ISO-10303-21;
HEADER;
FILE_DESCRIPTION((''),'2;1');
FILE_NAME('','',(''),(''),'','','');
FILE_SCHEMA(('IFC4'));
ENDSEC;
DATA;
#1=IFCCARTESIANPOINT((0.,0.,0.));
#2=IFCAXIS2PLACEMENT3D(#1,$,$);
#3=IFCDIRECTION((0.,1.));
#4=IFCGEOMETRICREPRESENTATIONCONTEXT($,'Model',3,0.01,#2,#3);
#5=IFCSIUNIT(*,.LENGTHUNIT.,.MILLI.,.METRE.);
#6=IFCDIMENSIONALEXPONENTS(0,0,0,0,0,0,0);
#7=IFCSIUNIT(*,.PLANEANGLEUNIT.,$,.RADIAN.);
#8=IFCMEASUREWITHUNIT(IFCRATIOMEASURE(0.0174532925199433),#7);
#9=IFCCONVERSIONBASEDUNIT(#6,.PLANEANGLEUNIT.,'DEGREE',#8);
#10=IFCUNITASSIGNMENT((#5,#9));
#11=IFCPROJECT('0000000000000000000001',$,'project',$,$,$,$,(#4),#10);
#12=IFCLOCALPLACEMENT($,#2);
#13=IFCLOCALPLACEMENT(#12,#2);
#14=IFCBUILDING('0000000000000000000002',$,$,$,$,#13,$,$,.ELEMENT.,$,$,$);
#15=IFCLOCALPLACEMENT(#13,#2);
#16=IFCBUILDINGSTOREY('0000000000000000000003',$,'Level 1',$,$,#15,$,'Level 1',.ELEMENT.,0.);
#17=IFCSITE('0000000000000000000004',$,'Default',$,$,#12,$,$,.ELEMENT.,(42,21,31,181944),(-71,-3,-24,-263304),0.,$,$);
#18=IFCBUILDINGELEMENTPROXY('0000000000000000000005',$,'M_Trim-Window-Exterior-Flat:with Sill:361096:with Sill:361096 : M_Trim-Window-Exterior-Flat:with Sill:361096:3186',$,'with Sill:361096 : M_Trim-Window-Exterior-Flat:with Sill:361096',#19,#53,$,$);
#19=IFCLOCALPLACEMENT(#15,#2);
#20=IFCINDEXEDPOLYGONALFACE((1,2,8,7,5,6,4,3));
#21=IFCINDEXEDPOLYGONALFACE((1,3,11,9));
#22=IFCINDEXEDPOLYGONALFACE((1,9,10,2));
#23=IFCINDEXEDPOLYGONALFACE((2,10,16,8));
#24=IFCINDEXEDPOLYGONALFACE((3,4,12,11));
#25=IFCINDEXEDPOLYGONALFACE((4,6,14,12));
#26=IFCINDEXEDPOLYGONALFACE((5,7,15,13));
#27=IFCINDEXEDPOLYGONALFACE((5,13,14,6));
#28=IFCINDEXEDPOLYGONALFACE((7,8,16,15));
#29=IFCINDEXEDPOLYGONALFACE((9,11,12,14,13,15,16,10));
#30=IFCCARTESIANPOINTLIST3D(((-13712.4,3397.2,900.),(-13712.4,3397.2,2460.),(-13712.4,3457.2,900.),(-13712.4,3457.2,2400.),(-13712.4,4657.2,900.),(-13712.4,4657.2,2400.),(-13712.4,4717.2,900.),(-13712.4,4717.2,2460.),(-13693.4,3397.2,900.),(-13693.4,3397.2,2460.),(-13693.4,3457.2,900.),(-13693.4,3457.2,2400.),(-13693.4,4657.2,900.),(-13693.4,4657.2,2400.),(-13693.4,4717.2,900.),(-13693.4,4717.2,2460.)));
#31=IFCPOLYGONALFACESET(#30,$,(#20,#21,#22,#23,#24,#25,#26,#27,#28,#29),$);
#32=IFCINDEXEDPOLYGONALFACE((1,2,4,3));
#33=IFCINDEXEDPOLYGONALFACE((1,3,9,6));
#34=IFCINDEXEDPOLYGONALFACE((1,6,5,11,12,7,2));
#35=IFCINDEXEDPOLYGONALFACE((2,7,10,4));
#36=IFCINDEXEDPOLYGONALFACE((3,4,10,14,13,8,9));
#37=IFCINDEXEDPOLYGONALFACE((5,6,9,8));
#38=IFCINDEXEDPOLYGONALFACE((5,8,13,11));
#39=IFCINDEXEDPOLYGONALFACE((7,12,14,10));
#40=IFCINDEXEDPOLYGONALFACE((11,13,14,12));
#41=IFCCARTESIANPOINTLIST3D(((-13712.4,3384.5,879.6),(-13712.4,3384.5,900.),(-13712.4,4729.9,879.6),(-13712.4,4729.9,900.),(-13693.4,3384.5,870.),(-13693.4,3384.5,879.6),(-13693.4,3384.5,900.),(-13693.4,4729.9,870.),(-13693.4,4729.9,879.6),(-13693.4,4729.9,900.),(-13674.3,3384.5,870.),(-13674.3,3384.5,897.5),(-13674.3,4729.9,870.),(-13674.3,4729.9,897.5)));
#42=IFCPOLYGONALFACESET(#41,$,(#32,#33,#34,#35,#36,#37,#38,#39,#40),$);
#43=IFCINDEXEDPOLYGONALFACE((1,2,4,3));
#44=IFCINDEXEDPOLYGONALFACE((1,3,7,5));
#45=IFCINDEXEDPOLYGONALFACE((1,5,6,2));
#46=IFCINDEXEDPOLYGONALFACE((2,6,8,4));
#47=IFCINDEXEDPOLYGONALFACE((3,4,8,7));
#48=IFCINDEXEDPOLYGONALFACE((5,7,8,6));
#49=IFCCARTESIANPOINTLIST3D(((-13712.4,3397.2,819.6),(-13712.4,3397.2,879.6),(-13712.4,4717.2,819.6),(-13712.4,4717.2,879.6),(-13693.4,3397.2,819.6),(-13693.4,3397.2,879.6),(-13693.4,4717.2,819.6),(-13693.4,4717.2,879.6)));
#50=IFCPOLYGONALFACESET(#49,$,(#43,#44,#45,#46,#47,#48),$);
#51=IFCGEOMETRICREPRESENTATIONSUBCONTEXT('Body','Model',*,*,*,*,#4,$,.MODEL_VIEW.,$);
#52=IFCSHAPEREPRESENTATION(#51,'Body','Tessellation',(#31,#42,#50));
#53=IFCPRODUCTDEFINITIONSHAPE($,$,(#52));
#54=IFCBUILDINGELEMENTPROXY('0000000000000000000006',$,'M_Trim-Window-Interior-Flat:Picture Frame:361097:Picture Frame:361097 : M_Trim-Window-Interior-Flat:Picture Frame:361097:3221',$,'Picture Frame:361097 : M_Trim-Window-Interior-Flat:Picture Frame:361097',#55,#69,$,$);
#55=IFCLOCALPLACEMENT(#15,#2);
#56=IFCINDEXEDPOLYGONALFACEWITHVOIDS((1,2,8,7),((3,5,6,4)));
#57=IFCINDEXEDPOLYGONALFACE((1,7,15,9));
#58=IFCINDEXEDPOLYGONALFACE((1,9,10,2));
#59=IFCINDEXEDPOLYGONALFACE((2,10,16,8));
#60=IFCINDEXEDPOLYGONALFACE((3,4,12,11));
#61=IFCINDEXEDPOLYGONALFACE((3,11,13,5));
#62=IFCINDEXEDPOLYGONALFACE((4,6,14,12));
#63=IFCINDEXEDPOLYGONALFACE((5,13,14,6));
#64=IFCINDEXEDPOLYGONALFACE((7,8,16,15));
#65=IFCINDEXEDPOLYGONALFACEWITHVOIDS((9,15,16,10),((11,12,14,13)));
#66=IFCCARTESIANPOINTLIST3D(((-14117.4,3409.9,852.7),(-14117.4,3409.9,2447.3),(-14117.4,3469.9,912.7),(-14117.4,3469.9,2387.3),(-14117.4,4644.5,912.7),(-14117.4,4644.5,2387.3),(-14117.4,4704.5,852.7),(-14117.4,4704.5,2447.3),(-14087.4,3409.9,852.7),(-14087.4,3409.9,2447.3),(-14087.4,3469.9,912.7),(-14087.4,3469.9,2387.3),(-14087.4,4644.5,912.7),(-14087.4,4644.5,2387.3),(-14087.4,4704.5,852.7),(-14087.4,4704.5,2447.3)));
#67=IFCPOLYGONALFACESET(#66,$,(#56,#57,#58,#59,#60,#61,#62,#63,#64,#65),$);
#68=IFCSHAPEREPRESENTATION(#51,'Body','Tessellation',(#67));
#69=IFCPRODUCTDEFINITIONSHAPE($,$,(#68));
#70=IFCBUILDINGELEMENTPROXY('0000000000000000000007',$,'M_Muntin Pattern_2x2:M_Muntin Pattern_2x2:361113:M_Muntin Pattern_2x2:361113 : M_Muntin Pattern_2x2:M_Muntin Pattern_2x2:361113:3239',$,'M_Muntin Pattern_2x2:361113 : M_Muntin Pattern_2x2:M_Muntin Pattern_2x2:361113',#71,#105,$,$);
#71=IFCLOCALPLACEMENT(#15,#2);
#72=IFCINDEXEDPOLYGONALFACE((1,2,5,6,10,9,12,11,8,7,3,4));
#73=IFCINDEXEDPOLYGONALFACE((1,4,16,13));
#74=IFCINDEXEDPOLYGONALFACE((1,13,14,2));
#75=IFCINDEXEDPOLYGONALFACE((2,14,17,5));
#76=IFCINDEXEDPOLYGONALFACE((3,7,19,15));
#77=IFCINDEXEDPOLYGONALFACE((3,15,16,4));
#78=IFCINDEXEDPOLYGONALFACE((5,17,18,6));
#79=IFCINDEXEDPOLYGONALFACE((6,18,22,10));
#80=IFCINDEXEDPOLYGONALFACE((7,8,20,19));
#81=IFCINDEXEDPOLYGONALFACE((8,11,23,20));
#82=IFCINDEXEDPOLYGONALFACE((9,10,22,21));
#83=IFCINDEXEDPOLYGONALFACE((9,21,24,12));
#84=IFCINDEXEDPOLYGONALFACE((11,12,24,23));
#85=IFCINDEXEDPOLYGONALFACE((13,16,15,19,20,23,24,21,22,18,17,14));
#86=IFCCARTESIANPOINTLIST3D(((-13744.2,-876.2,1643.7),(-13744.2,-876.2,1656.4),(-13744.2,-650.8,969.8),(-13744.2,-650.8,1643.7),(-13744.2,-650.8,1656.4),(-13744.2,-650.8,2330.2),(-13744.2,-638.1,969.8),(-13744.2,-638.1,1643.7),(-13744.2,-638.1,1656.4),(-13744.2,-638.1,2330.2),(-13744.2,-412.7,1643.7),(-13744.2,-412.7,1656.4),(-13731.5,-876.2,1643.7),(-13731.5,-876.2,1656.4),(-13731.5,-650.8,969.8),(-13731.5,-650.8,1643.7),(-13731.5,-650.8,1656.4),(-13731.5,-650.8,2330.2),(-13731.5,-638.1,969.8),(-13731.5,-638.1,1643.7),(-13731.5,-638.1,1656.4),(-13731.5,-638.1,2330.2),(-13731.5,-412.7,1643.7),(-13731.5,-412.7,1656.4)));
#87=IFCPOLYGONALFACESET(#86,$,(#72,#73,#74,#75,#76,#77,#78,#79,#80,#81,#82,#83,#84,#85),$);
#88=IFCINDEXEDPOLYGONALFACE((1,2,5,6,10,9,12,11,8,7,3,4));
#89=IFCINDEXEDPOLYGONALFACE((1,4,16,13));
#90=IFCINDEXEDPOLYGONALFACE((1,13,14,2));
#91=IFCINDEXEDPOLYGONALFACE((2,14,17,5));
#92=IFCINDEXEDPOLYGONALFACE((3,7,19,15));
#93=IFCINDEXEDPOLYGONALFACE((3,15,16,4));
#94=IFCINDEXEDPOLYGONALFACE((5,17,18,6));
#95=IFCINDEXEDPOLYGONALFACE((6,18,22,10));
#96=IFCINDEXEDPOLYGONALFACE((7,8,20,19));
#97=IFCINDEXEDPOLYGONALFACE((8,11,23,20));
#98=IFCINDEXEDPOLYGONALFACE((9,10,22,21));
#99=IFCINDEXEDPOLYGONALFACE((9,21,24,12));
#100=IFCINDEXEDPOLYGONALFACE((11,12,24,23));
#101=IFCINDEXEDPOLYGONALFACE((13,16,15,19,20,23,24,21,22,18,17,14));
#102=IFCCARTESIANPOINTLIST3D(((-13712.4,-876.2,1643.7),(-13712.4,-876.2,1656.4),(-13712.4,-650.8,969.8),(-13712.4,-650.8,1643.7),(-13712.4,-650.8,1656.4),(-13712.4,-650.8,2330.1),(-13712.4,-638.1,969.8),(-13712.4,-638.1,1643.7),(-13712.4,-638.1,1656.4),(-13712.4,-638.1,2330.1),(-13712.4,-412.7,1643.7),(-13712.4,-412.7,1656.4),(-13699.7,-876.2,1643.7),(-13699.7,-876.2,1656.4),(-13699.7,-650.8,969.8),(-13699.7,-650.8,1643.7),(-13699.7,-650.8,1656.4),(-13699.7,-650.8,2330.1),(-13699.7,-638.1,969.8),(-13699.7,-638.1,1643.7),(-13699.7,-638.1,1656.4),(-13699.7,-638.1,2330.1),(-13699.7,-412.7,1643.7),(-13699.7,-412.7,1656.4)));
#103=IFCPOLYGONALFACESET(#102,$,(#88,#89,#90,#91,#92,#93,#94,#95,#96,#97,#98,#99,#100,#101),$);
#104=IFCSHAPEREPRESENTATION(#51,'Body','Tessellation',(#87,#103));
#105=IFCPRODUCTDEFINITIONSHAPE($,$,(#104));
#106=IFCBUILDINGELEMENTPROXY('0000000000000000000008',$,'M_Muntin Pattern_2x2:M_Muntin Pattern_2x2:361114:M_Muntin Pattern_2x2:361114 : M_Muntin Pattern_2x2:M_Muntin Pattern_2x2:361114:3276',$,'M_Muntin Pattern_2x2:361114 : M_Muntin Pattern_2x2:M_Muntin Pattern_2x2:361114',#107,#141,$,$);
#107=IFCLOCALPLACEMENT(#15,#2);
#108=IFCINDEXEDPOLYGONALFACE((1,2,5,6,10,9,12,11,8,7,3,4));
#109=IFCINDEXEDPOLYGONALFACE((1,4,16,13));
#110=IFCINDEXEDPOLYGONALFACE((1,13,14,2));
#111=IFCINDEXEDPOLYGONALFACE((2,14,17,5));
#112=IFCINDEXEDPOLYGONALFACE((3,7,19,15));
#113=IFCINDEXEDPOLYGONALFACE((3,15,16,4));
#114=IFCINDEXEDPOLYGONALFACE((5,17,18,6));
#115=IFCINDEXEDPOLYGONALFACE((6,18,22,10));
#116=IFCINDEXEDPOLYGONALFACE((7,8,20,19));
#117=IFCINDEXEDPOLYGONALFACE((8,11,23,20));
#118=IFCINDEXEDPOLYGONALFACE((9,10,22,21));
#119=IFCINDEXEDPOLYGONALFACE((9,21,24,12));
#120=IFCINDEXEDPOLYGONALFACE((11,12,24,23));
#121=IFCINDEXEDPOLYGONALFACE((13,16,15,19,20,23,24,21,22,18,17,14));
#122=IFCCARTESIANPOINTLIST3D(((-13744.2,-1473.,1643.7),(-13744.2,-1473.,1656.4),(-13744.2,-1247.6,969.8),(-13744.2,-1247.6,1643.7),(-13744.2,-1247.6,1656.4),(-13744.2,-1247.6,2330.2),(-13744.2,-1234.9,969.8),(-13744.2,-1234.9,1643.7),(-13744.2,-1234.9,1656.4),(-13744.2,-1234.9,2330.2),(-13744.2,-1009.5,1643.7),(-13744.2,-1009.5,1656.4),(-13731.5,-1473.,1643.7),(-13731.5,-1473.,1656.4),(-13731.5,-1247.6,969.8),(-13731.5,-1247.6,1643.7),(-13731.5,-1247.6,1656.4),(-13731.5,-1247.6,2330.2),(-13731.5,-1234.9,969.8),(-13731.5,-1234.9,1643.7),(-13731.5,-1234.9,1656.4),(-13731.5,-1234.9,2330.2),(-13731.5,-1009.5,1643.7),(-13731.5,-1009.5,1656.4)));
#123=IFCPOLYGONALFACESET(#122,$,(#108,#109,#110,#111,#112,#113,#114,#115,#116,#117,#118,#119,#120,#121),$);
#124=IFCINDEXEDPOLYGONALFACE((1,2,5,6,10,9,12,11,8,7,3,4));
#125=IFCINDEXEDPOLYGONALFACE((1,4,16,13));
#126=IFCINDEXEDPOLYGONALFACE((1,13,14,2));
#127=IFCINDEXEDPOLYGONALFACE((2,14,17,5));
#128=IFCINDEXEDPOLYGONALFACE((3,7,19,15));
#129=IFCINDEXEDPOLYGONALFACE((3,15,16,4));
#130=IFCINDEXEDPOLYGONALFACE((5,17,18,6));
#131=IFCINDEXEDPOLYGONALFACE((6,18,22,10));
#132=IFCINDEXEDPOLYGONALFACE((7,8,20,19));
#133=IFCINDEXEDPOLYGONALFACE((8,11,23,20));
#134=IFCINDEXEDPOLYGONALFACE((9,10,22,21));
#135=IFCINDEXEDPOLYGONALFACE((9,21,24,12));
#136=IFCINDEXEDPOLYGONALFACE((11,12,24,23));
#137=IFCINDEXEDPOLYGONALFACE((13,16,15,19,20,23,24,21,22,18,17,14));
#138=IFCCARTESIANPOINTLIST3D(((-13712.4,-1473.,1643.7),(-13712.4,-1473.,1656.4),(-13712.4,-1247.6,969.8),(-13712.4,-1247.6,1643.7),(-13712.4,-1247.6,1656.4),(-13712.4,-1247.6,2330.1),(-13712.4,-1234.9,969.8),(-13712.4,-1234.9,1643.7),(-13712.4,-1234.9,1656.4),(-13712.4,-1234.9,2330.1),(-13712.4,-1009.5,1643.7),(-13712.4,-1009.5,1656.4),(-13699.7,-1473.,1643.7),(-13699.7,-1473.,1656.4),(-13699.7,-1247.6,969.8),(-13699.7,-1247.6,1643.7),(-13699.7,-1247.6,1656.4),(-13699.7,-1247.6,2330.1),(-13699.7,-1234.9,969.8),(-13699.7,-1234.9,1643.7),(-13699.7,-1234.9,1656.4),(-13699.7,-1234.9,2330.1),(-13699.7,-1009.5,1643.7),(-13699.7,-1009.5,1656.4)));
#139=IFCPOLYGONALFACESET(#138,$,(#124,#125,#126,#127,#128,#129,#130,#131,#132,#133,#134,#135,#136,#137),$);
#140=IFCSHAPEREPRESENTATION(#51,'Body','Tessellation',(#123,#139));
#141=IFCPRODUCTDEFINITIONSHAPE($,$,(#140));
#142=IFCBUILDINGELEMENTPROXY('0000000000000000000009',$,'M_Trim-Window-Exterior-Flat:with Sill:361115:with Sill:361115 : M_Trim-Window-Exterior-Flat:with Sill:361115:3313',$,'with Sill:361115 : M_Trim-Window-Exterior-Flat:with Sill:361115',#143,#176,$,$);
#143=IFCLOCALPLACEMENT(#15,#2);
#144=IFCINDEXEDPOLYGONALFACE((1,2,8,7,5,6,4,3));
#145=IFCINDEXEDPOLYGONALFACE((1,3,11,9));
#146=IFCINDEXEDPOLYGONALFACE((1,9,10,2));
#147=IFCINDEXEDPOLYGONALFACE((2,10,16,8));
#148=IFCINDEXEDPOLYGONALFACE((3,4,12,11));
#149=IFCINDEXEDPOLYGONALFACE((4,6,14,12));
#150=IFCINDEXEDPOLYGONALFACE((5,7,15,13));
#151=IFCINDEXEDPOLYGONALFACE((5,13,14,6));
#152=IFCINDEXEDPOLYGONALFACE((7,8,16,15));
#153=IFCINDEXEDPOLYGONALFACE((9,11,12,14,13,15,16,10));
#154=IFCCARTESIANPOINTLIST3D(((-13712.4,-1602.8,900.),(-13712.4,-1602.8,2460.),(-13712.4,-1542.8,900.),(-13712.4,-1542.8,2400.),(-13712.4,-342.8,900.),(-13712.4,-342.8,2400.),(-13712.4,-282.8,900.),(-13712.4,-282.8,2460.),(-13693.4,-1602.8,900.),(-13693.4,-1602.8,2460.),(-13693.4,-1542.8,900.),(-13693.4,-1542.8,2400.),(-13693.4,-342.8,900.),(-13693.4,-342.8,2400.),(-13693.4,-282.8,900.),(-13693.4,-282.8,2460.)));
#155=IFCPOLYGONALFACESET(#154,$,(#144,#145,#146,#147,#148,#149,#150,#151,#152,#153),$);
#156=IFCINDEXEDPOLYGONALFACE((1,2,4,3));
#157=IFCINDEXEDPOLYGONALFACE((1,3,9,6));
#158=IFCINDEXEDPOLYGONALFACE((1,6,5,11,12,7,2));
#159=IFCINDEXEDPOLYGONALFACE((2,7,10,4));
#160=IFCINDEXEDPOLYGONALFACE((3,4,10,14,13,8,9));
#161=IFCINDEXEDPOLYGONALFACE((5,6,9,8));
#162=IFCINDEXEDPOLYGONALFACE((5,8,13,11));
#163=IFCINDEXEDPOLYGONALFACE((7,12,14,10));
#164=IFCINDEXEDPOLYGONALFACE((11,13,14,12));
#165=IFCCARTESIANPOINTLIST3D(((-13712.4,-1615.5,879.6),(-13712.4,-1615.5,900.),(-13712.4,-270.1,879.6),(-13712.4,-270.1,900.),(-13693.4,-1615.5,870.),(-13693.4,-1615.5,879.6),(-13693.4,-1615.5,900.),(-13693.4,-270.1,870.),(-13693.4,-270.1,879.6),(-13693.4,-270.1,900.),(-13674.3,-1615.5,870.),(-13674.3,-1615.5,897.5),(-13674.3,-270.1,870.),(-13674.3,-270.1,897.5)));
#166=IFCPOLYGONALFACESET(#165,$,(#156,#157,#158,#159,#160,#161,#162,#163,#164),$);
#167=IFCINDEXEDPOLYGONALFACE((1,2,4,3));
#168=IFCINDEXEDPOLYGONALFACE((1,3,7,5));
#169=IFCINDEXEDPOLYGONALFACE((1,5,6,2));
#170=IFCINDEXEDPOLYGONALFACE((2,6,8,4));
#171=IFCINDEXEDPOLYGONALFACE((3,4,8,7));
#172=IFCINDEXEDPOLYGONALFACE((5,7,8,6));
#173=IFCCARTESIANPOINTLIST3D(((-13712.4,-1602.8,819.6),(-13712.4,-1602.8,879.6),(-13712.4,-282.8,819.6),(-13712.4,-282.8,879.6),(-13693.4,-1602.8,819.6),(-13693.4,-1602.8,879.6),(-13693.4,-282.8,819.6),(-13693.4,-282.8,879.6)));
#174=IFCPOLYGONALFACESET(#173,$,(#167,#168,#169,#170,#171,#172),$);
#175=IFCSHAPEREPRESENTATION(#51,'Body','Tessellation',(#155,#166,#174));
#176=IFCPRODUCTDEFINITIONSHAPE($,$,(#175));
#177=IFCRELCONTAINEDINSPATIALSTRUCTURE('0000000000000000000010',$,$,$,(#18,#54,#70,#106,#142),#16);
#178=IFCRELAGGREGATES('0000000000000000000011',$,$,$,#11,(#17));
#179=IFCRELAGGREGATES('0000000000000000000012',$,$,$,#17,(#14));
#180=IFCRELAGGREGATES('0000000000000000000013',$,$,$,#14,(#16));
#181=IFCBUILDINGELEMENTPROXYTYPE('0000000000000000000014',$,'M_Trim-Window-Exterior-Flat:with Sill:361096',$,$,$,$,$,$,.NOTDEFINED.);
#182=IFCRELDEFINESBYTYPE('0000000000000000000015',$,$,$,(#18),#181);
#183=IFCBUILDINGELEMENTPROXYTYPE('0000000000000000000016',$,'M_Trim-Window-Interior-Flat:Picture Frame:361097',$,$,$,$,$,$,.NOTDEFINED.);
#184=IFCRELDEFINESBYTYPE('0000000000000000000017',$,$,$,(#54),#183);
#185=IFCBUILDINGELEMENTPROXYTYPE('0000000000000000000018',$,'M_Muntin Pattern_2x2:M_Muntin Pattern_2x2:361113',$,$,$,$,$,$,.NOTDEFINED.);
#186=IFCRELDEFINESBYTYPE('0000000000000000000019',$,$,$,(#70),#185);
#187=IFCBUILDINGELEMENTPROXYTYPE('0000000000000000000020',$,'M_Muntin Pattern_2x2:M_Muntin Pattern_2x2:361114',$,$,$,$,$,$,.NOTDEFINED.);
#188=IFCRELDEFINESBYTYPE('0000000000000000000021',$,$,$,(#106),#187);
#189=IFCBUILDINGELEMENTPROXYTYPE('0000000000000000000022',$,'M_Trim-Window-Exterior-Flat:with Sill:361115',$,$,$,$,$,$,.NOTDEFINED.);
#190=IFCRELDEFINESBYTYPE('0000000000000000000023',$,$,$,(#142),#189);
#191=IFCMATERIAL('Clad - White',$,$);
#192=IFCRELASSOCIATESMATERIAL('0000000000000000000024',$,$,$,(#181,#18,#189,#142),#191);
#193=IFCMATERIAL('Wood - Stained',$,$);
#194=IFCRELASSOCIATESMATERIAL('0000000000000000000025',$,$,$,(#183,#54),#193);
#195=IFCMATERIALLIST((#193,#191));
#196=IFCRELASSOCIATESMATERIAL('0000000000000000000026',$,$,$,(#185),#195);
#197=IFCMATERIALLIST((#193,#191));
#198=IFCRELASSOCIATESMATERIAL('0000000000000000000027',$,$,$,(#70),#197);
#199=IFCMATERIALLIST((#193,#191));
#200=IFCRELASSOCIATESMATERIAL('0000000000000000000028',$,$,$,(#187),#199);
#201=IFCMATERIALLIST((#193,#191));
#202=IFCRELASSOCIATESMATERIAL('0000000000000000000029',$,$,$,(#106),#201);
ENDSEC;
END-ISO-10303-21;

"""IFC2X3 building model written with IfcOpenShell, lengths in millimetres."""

from ifc_helpers import new_model, entity, si_unit, converted_unit, direction, frame, frame_2d, origin, origin_2d_with_axis, place, context, subcontext, project, spatial, polyline, rectangle, outline, extrude, source, transform, mapped, material, material_list, type_object, type_shapes, element, save


model = new_model("IFC2X3")

# Units and contexts
model_context = context("Model", 3, precision=0.01, world=origin(), true_north=direction((0.0, 1.0)))
body_context = subcontext(model_context, "Body", "Model", "MODEL_VIEW")
ifc_project = project(units=[si_unit("LENGTHUNIT", "METRE", prefix="MILLI"), converted_unit("PLANEANGLEUNIT", "DEGREE", entity("IfcRatioMeasure", 0.0174532925199433), si_unit("PLANEANGLEUNIT", "RADIAN"), dimensions=[0, 0, 0, 0, 0, 0, 0])], contexts=[model_context])

# Site, building, storey
site_placement = place(None, origin())
site = spatial("IfcSite", under=ifc_project, at=site_placement, Name="Default", CompositionType="ELEMENT", RefLatitude=(42, 21, 31, 181944), RefLongitude=(-71, -3, -24, -263304), RefElevation=0.0)
building_placement = place(site_placement, origin())
building = spatial("IfcBuilding", under=site, at=building_placement, CompositionType="ELEMENT")
storey_placement = place(building_placement, origin())
storey = spatial("IfcBuildingStorey", under=building, at=storey_placement, Name="Level 1", LongName="Level 1", CompositionType="ELEMENT", Elevation=0.0)

# Building element proxies
ifc_material_1 = material(Name="Wood - Stained")
ifc_material_2 = material(Name="Clad - White")
building_element_proxy_type_1 = type_object("IfcBuildingElementProxyType", Name="M_Trim-Window-Exterior-Flat:with Sill:361096", PredefinedType="NOTDEFINED", material=ifc_material_2)
shared_shape_1 = source(origin(), body_context, "Body", "SweptSolid", [
    extrude(outline(polyline([(-660.0, -765.0), (-600.0, -765.0), (-600.0, 735.0), (600.0, 735.0), (600.0, -765.0), (660.0, -765.0), (660.0, 795.0), (-660.0, 795.0), (-660.0, -765.0)])), frame((-13712.4, 4057.2, 1665.0), z_axis=(1.0, 0.0, 0.0), x_axis=(0.0, 1.0, 0.0)), (0.0, 0.0, 1.0), 19.1),
    extrude(outline(polyline([(-15.2, 0.0), (-15.2, -19.0), (12.3, -19.0), (14.8, 0.0), (14.8, 19.0), (-5.7, 19.0), (-5.7, 0.0), (-15.2, 0.0)])), frame((-13693.4, 3384.5, 885.2), z_axis=(0.0, -1.0, 0.0), x_axis=(0.0, 0.0, 1.0)), (0.0, 0.0, -1.0), 1345.4),
    extrude(rectangle(XDim=19.1, YDim=1320.0, at=frame_2d((0.0, 0.0), x_axis=(1.0, 0.0))), frame((-13702.9, 4057.2, 819.6), z_axis=(0.0, 0.0, 1.0), x_axis=(-1.0, 0.0, 0.0)), (0.0, 0.0, 1.0), 60.0),
])
type_shapes(building_element_proxy_type_1, [shared_shape_1])
proxy_1_placement = place(storey_placement, origin())
element("IfcBuildingElementProxy", 1, at=proxy_1_placement, inside=storey, type_object=building_element_proxy_type_1, material=ifc_material_2, Name="M_Trim-Window-Exterior-Flat:with Sill:361096:with Sill:361096 : M_Trim-Window-Exterior-Flat:with Sill:361096:3186", ObjectType="with Sill:361096 : M_Trim-Window-Exterior-Flat:with Sill:361096", context=body_context, shape_type="MappedRepresentation", body=[
    mapped(shared_shape_1, transform((0.0, 0.0, 0.0), scale=1.0)),
])
building_element_proxy_type_2 = type_object("IfcBuildingElementProxyType", Name="M_Trim-Window-Interior-Flat:Picture Frame:361097", PredefinedType="NOTDEFINED", material=ifc_material_1)
shared_shape_2 = source(origin(), body_context, "Body", "SweptSolid", [
    extrude(outline(polyline([(-647.3, -797.3), (647.3, -797.3), (647.3, 797.3), (-647.3, 797.3), (-647.3, -797.3)]), holes=[polyline([(587.3, 737.3), (587.3, -737.3), (-587.3, -737.3), (-587.3, 737.3), (587.3, 737.3)])]), frame((-14117.4, 4057.2, 1650.0), z_axis=(1.0, 0.0, 0.0), x_axis=(0.0, -1.0, 0.0)), (0.0, 0.0, 1.0), 30.0),
])
type_shapes(building_element_proxy_type_2, [shared_shape_2])
proxy_2_placement = place(storey_placement, origin())
element("IfcBuildingElementProxy", 2, at=proxy_2_placement, inside=storey, type_object=building_element_proxy_type_2, material=ifc_material_1, Name="M_Trim-Window-Interior-Flat:Picture Frame:361097:Picture Frame:361097 : M_Trim-Window-Interior-Flat:Picture Frame:361097:3221", ObjectType="Picture Frame:361097 : M_Trim-Window-Interior-Flat:Picture Frame:361097", context=body_context, shape_type="MappedRepresentation", body=[
    mapped(shared_shape_2, transform((0.0, 0.0, 0.0), scale=1.0)),
])
ifc_material_list_1 = material_list([ifc_material_1, ifc_material_2])
ifc_material_list_2 = material_list([ifc_material_1, ifc_material_2])
building_element_proxy_type_3 = type_object("IfcBuildingElementProxyType", Name="M_Muntin Pattern_2x2:M_Muntin Pattern_2x2:361113", PredefinedType="NOTDEFINED", material=ifc_material_list_2)
shared_shape_3 = source(origin(), body_context, "Body", "SweptSolid", [
    extrude(outline(polyline([(-6.4, -680.2), (6.3, -680.2), (6.3, -6.4), (231.7, -6.4), (231.7, 6.3), (6.3, 6.3), (6.3, 680.2), (-6.4, 680.2), (-6.4, 6.3), (-231.7, 6.3), (-231.7, -6.4), (-6.4, -6.4), (-6.4, -680.2)])), frame((-13744.2, -644.4, 1650.0), z_axis=(1.0, 0.0, 0.0), x_axis=(0.0, -1.0, 0.0)), (0.0, 0.0, 1.0), 12.7),
    extrude(outline(polyline([(-6.4, -680.1), (6.3, -680.1), (6.3, -6.4), (231.7, -6.4), (231.7, 6.3), (6.3, 6.3), (6.3, 680.2), (-6.4, 680.2), (-6.4, 6.3), (-231.7, 6.3), (-231.7, -6.4), (-6.4, -6.4), (-6.4, -680.1)])), frame((-13712.4, -644.4, 1650.0), z_axis=(1.0, 0.0, 0.0), x_axis=(0.0, -1.0, 0.0)), (0.0, 0.0, 1.0), 12.7),
])
type_shapes(building_element_proxy_type_3, [shared_shape_3])
proxy_3_placement = place(storey_placement, origin())
element("IfcBuildingElementProxy", 3, at=proxy_3_placement, inside=storey, type_object=building_element_proxy_type_3, material=ifc_material_list_1, Name="M_Muntin Pattern_2x2:M_Muntin Pattern_2x2:361113:M_Muntin Pattern_2x2:361113 : M_Muntin Pattern_2x2:M_Muntin Pattern_2x2:361113:3239", ObjectType="M_Muntin Pattern_2x2:361113 : M_Muntin Pattern_2x2:M_Muntin Pattern_2x2:361113", context=body_context, shape_type="MappedRepresentation", body=[
    mapped(shared_shape_3, transform((0.0, 0.0, 0.0), scale=1.0)),
])
ifc_material_list_3 = material_list([ifc_material_1, ifc_material_2])
ifc_material_list_4 = material_list([ifc_material_1, ifc_material_2])
building_element_proxy_type_4 = type_object("IfcBuildingElementProxyType", Name="M_Muntin Pattern_2x2:M_Muntin Pattern_2x2:361114", PredefinedType="NOTDEFINED", material=ifc_material_list_4)
shared_shape_4 = source(origin(), body_context, "Body", "SweptSolid", [
    extrude(outline(polyline([(-680.1, 6.4), (-680.1, -6.3), (-6.4, -6.3), (-6.4, -231.7), (6.3, -231.7), (6.3, -6.3), (680.2, -6.3), (680.2, 6.4), (6.3, 6.4), (6.3, 231.7), (-6.4, 231.7), (-6.4, 6.4), (-680.1, 6.4)])), frame((-13744.2, -1241.3, 1650.0), z_axis=(-1.0, 0.0, 0.0), x_axis=(0.0, 0.0, -1.0)), (0.0, 0.0, -1.0), 12.7),
    extrude(outline(polyline([(-680.1, 6.4), (-680.1, -6.3), (-6.4, -6.3), (-6.4, -231.7), (6.3, -231.7), (6.3, -6.3), (680.2, -6.3), (680.2, 6.4), (6.3, 6.4), (6.3, 231.7), (-6.4, 231.7), (-6.4, 6.4), (-680.1, 6.4)])), frame((-13712.4, -1241.3, 1650.0), z_axis=(-1.0, 0.0, 0.0), x_axis=(0.0, 0.0, -1.0)), (0.0, 0.0, -1.0), 12.7),
])
type_shapes(building_element_proxy_type_4, [shared_shape_4])
proxy_4_placement = place(storey_placement, origin())
element("IfcBuildingElementProxy", 4, at=proxy_4_placement, inside=storey, type_object=building_element_proxy_type_4, material=ifc_material_list_3, Name="M_Muntin Pattern_2x2:M_Muntin Pattern_2x2:361114:M_Muntin Pattern_2x2:361114 : M_Muntin Pattern_2x2:M_Muntin Pattern_2x2:361114:3276", ObjectType="M_Muntin Pattern_2x2:361114 : M_Muntin Pattern_2x2:M_Muntin Pattern_2x2:361114", context=body_context, shape_type="MappedRepresentation", body=[
    mapped(shared_shape_4, transform((0.0, 0.0, 0.0), scale=1.0)),
])
building_element_proxy_type_5 = type_object("IfcBuildingElementProxyType", Name="M_Trim-Window-Exterior-Flat:with Sill:361115", PredefinedType="NOTDEFINED", material=ifc_material_2)
shared_shape_5 = source(origin(), body_context, "Body", "SweptSolid", [
    extrude(outline(polyline([(-660.0, -765.0), (-600.0, -765.0), (-600.0, 735.0), (600.0, 735.0), (600.0, -765.0), (660.0, -765.0), (660.0, 795.0), (-660.0, 795.0), (-660.0, -765.0)])), frame((-13712.4, -942.8, 1665.0), z_axis=(1.0, 0.0, 0.0), x_axis=(0.0, 1.0, 0.0)), (0.0, 0.0, 1.0), 19.1),
    extrude(outline(polyline([(-15.2, 0.0), (-15.2, -19.0), (12.3, -19.0), (14.8, 0.0), (14.8, 19.0), (-5.7, 19.0), (-5.7, 0.0), (-15.2, 0.0)])), frame((-13693.4, -1615.5, 885.2), z_axis=(0.0, -1.0, 0.0), x_axis=(0.0, 0.0, 1.0)), (0.0, 0.0, -1.0), 1345.4),
    extrude(rectangle(XDim=19.1, YDim=1320.0, at=origin_2d_with_axis()), frame((-13702.9, -942.8, 819.6), z_axis=(0.0, 0.0, 1.0), x_axis=(-1.0, 0.0, 0.0)), (0.0, 0.0, 1.0), 60.0),
])
type_shapes(building_element_proxy_type_5, [shared_shape_5])
proxy_5_placement = place(storey_placement, origin())
element("IfcBuildingElementProxy", 5, at=proxy_5_placement, inside=storey, type_object=building_element_proxy_type_5, material=ifc_material_2, Name="M_Trim-Window-Exterior-Flat:with Sill:361115:with Sill:361115 : M_Trim-Window-Exterior-Flat:with Sill:361115:3313", ObjectType="with Sill:361115 : M_Trim-Window-Exterior-Flat:with Sill:361115", context=body_context, shape_type="MappedRepresentation", body=[
    mapped(shared_shape_5, transform((0.0, 0.0, 0.0), scale=1.0)),
])

save(model, "model.ifc")
